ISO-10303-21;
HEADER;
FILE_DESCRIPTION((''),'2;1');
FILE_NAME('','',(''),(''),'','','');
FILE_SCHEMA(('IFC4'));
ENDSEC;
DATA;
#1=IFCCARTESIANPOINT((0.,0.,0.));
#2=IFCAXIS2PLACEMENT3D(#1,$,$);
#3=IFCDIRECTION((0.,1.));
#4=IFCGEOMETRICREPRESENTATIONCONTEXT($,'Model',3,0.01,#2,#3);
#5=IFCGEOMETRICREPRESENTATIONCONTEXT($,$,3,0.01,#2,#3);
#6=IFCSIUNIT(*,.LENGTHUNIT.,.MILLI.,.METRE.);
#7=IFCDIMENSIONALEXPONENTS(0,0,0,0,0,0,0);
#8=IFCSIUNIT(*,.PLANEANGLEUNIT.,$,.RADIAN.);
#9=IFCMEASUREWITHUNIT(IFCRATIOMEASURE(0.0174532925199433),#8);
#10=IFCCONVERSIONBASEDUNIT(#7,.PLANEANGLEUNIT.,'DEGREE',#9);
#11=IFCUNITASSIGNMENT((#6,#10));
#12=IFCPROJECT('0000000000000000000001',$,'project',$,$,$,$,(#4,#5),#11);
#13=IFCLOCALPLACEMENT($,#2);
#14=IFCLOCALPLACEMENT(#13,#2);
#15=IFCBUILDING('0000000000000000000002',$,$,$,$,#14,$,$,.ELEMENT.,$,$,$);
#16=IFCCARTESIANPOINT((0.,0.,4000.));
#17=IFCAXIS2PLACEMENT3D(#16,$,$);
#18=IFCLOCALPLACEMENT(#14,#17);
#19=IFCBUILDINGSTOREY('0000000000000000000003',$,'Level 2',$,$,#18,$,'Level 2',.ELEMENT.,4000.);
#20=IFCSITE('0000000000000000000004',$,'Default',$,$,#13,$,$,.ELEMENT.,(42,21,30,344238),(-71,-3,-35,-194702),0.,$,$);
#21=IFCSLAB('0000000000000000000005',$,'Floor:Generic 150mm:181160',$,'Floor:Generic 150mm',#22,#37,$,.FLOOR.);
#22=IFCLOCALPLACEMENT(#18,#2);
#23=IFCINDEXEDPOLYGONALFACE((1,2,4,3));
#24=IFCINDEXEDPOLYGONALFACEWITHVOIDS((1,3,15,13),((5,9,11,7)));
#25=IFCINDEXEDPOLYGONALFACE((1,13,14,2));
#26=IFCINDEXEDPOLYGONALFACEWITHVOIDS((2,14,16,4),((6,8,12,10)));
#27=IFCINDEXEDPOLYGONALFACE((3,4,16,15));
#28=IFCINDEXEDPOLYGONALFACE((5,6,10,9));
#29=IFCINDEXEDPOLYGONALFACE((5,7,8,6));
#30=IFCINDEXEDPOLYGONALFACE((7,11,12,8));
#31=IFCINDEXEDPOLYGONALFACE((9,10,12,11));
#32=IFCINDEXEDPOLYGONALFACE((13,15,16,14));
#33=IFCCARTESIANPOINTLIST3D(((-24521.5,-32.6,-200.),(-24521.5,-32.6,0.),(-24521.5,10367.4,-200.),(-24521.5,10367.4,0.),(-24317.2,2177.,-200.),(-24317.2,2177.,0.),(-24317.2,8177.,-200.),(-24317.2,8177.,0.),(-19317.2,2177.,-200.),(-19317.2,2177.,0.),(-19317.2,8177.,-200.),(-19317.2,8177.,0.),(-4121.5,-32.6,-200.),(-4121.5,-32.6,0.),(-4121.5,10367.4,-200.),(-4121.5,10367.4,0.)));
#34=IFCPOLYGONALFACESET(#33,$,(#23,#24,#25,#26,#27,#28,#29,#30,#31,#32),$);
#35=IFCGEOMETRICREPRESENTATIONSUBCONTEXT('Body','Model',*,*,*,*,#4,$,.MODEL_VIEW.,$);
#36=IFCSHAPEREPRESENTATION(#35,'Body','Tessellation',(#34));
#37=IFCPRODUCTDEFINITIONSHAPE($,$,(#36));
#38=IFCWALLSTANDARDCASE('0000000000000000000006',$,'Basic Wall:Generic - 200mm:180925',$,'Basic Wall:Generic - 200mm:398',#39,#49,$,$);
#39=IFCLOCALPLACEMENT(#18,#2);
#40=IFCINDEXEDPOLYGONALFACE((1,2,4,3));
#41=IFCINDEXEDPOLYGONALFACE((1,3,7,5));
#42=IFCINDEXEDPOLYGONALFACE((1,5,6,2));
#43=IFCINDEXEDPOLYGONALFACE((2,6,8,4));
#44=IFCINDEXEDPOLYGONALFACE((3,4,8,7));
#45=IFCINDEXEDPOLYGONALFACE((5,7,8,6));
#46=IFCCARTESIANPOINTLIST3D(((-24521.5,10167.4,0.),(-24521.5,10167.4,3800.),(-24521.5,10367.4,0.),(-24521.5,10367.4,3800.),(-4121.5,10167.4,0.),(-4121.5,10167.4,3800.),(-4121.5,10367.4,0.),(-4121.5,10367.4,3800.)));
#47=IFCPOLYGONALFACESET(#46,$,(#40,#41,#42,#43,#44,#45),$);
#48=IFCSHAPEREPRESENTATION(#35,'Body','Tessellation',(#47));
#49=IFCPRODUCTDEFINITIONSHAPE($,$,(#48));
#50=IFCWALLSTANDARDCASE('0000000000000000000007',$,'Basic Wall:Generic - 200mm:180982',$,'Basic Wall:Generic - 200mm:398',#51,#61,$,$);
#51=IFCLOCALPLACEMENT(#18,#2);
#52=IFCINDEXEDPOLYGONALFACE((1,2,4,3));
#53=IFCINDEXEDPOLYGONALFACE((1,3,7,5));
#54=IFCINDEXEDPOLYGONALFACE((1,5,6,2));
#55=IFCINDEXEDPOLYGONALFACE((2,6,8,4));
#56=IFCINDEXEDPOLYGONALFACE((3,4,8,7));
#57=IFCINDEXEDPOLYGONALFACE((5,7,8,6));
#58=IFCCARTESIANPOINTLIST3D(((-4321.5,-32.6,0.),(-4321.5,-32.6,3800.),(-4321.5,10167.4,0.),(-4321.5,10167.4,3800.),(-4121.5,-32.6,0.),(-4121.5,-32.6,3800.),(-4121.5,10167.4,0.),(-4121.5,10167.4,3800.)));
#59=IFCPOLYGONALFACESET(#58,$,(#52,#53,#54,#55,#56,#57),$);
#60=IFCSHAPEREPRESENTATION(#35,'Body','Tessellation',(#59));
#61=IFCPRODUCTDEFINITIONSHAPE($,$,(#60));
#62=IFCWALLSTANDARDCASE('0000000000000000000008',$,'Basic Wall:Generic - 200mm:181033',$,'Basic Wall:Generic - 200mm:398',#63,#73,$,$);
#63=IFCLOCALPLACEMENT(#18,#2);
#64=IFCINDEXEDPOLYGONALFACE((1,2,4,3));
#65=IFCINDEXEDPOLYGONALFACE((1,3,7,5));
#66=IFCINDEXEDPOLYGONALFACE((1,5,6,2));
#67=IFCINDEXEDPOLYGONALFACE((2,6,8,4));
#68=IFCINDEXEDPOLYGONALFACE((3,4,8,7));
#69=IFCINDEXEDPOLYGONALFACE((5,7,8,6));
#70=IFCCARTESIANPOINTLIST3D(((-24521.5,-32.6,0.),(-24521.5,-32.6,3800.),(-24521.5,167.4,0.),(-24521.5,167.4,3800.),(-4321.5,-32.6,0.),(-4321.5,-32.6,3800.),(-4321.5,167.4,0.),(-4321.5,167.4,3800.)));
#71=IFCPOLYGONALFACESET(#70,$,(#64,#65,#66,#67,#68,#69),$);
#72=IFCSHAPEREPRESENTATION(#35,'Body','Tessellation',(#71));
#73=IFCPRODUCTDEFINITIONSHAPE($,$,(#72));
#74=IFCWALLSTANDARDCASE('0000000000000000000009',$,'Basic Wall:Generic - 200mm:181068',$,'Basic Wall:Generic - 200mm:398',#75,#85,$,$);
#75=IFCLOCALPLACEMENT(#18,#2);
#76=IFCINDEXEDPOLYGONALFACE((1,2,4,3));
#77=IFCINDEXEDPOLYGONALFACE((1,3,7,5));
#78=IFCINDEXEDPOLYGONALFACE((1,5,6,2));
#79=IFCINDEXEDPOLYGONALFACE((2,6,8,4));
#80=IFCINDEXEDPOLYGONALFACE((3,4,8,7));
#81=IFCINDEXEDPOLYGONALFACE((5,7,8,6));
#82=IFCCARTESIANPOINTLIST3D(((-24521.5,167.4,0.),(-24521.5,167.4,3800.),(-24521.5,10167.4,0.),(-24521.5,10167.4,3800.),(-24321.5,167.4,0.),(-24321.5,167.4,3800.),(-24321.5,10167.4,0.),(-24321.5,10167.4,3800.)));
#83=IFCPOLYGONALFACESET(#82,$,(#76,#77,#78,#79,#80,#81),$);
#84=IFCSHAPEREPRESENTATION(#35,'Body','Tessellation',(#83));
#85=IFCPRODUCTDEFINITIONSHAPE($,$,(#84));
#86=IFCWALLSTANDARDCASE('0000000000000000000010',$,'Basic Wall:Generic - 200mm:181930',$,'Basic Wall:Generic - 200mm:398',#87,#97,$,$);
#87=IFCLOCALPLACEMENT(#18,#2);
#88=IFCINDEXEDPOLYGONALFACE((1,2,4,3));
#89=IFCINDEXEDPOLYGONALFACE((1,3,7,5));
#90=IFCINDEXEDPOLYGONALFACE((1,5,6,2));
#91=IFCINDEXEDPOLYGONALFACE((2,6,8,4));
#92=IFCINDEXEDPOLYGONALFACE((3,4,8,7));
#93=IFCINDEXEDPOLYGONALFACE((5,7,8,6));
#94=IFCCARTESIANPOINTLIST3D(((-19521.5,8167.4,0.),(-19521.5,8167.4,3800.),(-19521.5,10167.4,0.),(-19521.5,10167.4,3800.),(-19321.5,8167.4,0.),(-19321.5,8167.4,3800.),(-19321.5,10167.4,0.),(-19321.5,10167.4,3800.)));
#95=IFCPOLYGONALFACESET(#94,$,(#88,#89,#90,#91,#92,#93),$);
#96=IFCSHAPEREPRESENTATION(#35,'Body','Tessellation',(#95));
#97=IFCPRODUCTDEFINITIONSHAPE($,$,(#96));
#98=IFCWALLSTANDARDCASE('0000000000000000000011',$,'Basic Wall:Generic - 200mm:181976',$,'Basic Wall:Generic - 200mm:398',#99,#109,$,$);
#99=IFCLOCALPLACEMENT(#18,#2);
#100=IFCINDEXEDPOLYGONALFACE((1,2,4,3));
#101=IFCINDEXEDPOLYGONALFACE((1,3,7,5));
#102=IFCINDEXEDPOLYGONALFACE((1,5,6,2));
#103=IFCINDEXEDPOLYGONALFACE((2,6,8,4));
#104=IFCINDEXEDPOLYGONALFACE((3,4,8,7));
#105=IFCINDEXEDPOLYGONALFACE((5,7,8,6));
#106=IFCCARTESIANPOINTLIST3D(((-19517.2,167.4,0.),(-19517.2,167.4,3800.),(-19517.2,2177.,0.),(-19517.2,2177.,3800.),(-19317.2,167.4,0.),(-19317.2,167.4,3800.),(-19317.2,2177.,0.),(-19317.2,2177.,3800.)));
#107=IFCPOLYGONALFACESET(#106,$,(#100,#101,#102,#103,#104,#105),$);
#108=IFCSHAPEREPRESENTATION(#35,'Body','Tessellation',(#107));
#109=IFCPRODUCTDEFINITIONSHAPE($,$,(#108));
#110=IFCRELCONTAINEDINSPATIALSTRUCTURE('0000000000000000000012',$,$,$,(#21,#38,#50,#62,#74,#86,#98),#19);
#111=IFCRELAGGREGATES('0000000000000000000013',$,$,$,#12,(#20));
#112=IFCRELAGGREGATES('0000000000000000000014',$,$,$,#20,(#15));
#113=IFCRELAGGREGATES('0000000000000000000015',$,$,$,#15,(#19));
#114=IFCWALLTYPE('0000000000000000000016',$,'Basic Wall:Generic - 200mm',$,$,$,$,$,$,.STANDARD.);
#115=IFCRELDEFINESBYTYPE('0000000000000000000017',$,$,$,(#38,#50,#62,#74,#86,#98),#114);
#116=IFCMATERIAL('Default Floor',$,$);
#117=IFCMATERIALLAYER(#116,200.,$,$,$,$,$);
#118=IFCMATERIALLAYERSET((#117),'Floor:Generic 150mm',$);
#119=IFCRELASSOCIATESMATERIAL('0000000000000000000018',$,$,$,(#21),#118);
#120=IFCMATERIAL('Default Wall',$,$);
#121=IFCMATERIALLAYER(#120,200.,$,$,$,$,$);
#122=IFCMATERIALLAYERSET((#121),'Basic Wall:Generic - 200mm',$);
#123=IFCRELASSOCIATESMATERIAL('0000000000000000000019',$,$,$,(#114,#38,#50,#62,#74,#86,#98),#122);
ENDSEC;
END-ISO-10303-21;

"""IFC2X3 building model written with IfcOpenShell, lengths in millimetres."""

from ifc_helpers import new_model, entity, si_unit, converted_unit, direction, frame, frame_2d, origin, origin_2d_with_axis, place, context, subcontext, project, spatial, rectangle, extrude, material, layer, layer_set, layer_usage, type_object, element, save


model = new_model("IFC2X3")

# Units and contexts
model_context = context("Model", 3, precision=0.01, world=origin(), true_north=direction((0.0, 1.0)))
context_of_model = context(None, 3, precision=0.01, world=origin(), true_north=direction((0.0, 1.0)))
body_context = subcontext(model_context, "Body", "Model", "MODEL_VIEW")
ifc_project = project(units=[si_unit("LENGTHUNIT", "METRE", prefix="MILLI"), converted_unit("PLANEANGLEUNIT", "DEGREE", entity("IfcRatioMeasure", 0.0174532925199433), si_unit("PLANEANGLEUNIT", "RADIAN"), dimensions=[0, 0, 0, 0, 0, 0, 0])], contexts=[model_context, context_of_model])

# Site, building, storey
site_placement = place(None, origin())
site = spatial("IfcSite", under=ifc_project, at=site_placement, Name="Default", CompositionType="ELEMENT", RefLatitude=(42, 21, 30, 344238), RefLongitude=(-71, -3, -35, -194702), RefElevation=0.0)
building_placement = place(site_placement, origin())
building = spatial("IfcBuilding", under=site, at=building_placement, CompositionType="ELEMENT")
storey_placement = place(building_placement, frame((0.0, 0.0, 4000.0)))
storey = spatial("IfcBuildingStorey", under=building, at=storey_placement, Name="Level 2", LongName="Level 2", CompositionType="ELEMENT", Elevation=4000.0)

# Slab, opening
ifc_material_1 = material(Name="Default Floor")
ifc_layer_1 = layer(ifc_material_1, 200.0)
ifc_layer_set_1 = layer_set([ifc_layer_1], Name="Floor:Generic 150mm")
ifc_layer_usage_1 = layer_usage(ifc_layer_set_1, "AXIS3", "POSITIVE", 0.0)
slab_placement = place(storey_placement, frame((-24521.5, -32.6, -200.0)))
slab = element("IfcSlab", 1, at=slab_placement, inside=storey, material=ifc_layer_usage_1, Name="Floor:Generic 150mm:181160", ObjectType="Floor:Generic 150mm", PredefinedType="FLOOR", context=body_context, shape_type="SweptSolid", body=[
    extrude(rectangle(XDim=10400.0, YDim=20400.0, at=frame_2d((0.0, 0.0), x_axis=(0.0, -1.0))), frame((10200.0, 5200.0, 200.0), z_axis=(0.0, 0.0, -1.0), x_axis=(-1.0, 0.0, 0.0)), (0.0, 0.0, 1.0), 200.0),
])
opening_placement = place(slab_placement, frame((2704.3, 5209.6, 200.0)))
element("IfcOpeningElement", 2, at=opening_placement, cuts=slab, ObjectType="Opening", context=body_context, shape_type="SweptSolid", body=[
    extrude(rectangle(XDim=5000.0, YDim=6000.0, at=origin_2d_with_axis()), frame((0.0, 0.0, 0.0), z_axis=(0.0, 0.0, -1.0), x_axis=(1.0, 0.0, 0.0)), (0.0, 0.0, 1.0), 200.0),
])

# Walls
ifc_material_2 = material(Name="Default Wall")
ifc_layer_2 = layer(ifc_material_2, 200.0)
ifc_layer_set_2 = layer_set([ifc_layer_2], Name="Basic Wall:Generic - 200mm")
ifc_layer_usage_2 = layer_usage(ifc_layer_set_2, "AXIS2", "NEGATIVE", 100.0)
wall_type = type_object("IfcWallType", Name="Basic Wall:Generic - 200mm", PredefinedType="STANDARD", material=ifc_layer_set_2)
wall_1_placement = place(storey_placement, frame((-24521.5, 10267.4, 0.0)))
element("IfcWallStandardCase", 3, at=wall_1_placement, inside=storey, type_object=wall_type, material=ifc_layer_usage_2, Name="Basic Wall:Generic - 200mm:180925", ObjectType="Basic Wall:Generic - 200mm:398", context=body_context, shape_type="SweptSolid", body=[
    extrude(rectangle(XDim=20400.0, YDim=200.0, at=frame_2d((10200.0, 0.0), x_axis=(-1.0, 0.0))), origin(), (0.0, 0.0, 1.0), 3800.0),
])
ifc_layer_usage_3 = layer_usage(ifc_layer_set_2, "AXIS2", "NEGATIVE", 100.0)
wall_2_placement = place(storey_placement, frame((-4221.5, 10167.4, 0.0), z_axis=(0.0, 0.0, 1.0), x_axis=(0.0, -1.0, 0.0)))
element("IfcWallStandardCase", 4, at=wall_2_placement, inside=storey, type_object=wall_type, material=ifc_layer_usage_3, Name="Basic Wall:Generic - 200mm:180982", ObjectType="Basic Wall:Generic - 200mm:398", context=body_context, shape_type="SweptSolid", body=[
    extrude(rectangle(XDim=10200.0, YDim=200.0, at=frame_2d((5100.0, 0.0), x_axis=(-1.0, 0.0))), origin(), (0.0, 0.0, 1.0), 3800.0),
])
ifc_layer_usage_4 = layer_usage(ifc_layer_set_2, "AXIS2", "NEGATIVE", 100.0)
wall_3_placement = place(storey_placement, frame((-4321.5, 67.4, 0.0), z_axis=(0.0, 0.0, 1.0), x_axis=(-1.0, 0.0, 0.0)))
element("IfcWallStandardCase", 5, at=wall_3_placement, inside=storey, type_object=wall_type, material=ifc_layer_usage_4, Name="Basic Wall:Generic - 200mm:181033", ObjectType="Basic Wall:Generic - 200mm:398", context=body_context, shape_type="SweptSolid", body=[
    extrude(rectangle(XDim=20200.0, YDim=200.0, at=frame_2d((10100.0, 0.0), x_axis=(-1.0, 0.0))), origin(), (0.0, 0.0, 1.0), 3800.0),
])
ifc_layer_usage_5 = layer_usage(ifc_layer_set_2, "AXIS2", "NEGATIVE", 100.0)
wall_4_placement = place(storey_placement, frame((-24421.5, 167.4, 0.0), z_axis=(0.0, 0.0, 1.0), x_axis=(0.0, 1.0, 0.0)))
element("IfcWallStandardCase", 6, at=wall_4_placement, inside=storey, type_object=wall_type, material=ifc_layer_usage_5, Name="Basic Wall:Generic - 200mm:181068", ObjectType="Basic Wall:Generic - 200mm:398", context=body_context, shape_type="SweptSolid", body=[
    extrude(rectangle(XDim=10000.0, YDim=200.0, at=frame_2d((5000.0, 0.0), x_axis=(-1.0, 0.0))), origin(), (0.0, 0.0, 1.0), 3800.0),
])
ifc_layer_usage_6 = layer_usage(ifc_layer_set_2, "AXIS2", "NEGATIVE", 100.0)
wall_5_placement = place(storey_placement, frame((-19421.5, 10167.4, 0.0), z_axis=(0.0, 0.0, 1.0), x_axis=(0.0, -1.0, 0.0)))
element("IfcWallStandardCase", 7, at=wall_5_placement, inside=storey, type_object=wall_type, material=ifc_layer_usage_6, Name="Basic Wall:Generic - 200mm:181930", ObjectType="Basic Wall:Generic - 200mm:398", context=body_context, shape_type="SweptSolid", body=[
    extrude(rectangle(XDim=2000.0, YDim=200.0, at=frame_2d((1000.0, 0.0), x_axis=(-1.0, 0.0))), origin(), (0.0, 0.0, 1.0), 3800.0),
])
ifc_layer_usage_7 = layer_usage(ifc_layer_set_2, "AXIS2", "NEGATIVE", 100.0)
wall_6_placement = place(storey_placement, frame((-19417.2, 2177.0, 0.0), z_axis=(0.0, 0.0, 1.0), x_axis=(0.0, -1.0, 0.0)))
element("IfcWallStandardCase", 8, at=wall_6_placement, inside=storey, type_object=wall_type, material=ifc_layer_usage_7, Name="Basic Wall:Generic - 200mm:181976", ObjectType="Basic Wall:Generic - 200mm:398", context=body_context, shape_type="SweptSolid", body=[
    extrude(rectangle(XDim=2009.6, YDim=200.0, at=frame_2d((1004.8, 0.0), x_axis=(-1.0, 0.0))), origin(), (0.0, 0.0, 1.0), 3800.0),
])

save(model, "model.ifc")
